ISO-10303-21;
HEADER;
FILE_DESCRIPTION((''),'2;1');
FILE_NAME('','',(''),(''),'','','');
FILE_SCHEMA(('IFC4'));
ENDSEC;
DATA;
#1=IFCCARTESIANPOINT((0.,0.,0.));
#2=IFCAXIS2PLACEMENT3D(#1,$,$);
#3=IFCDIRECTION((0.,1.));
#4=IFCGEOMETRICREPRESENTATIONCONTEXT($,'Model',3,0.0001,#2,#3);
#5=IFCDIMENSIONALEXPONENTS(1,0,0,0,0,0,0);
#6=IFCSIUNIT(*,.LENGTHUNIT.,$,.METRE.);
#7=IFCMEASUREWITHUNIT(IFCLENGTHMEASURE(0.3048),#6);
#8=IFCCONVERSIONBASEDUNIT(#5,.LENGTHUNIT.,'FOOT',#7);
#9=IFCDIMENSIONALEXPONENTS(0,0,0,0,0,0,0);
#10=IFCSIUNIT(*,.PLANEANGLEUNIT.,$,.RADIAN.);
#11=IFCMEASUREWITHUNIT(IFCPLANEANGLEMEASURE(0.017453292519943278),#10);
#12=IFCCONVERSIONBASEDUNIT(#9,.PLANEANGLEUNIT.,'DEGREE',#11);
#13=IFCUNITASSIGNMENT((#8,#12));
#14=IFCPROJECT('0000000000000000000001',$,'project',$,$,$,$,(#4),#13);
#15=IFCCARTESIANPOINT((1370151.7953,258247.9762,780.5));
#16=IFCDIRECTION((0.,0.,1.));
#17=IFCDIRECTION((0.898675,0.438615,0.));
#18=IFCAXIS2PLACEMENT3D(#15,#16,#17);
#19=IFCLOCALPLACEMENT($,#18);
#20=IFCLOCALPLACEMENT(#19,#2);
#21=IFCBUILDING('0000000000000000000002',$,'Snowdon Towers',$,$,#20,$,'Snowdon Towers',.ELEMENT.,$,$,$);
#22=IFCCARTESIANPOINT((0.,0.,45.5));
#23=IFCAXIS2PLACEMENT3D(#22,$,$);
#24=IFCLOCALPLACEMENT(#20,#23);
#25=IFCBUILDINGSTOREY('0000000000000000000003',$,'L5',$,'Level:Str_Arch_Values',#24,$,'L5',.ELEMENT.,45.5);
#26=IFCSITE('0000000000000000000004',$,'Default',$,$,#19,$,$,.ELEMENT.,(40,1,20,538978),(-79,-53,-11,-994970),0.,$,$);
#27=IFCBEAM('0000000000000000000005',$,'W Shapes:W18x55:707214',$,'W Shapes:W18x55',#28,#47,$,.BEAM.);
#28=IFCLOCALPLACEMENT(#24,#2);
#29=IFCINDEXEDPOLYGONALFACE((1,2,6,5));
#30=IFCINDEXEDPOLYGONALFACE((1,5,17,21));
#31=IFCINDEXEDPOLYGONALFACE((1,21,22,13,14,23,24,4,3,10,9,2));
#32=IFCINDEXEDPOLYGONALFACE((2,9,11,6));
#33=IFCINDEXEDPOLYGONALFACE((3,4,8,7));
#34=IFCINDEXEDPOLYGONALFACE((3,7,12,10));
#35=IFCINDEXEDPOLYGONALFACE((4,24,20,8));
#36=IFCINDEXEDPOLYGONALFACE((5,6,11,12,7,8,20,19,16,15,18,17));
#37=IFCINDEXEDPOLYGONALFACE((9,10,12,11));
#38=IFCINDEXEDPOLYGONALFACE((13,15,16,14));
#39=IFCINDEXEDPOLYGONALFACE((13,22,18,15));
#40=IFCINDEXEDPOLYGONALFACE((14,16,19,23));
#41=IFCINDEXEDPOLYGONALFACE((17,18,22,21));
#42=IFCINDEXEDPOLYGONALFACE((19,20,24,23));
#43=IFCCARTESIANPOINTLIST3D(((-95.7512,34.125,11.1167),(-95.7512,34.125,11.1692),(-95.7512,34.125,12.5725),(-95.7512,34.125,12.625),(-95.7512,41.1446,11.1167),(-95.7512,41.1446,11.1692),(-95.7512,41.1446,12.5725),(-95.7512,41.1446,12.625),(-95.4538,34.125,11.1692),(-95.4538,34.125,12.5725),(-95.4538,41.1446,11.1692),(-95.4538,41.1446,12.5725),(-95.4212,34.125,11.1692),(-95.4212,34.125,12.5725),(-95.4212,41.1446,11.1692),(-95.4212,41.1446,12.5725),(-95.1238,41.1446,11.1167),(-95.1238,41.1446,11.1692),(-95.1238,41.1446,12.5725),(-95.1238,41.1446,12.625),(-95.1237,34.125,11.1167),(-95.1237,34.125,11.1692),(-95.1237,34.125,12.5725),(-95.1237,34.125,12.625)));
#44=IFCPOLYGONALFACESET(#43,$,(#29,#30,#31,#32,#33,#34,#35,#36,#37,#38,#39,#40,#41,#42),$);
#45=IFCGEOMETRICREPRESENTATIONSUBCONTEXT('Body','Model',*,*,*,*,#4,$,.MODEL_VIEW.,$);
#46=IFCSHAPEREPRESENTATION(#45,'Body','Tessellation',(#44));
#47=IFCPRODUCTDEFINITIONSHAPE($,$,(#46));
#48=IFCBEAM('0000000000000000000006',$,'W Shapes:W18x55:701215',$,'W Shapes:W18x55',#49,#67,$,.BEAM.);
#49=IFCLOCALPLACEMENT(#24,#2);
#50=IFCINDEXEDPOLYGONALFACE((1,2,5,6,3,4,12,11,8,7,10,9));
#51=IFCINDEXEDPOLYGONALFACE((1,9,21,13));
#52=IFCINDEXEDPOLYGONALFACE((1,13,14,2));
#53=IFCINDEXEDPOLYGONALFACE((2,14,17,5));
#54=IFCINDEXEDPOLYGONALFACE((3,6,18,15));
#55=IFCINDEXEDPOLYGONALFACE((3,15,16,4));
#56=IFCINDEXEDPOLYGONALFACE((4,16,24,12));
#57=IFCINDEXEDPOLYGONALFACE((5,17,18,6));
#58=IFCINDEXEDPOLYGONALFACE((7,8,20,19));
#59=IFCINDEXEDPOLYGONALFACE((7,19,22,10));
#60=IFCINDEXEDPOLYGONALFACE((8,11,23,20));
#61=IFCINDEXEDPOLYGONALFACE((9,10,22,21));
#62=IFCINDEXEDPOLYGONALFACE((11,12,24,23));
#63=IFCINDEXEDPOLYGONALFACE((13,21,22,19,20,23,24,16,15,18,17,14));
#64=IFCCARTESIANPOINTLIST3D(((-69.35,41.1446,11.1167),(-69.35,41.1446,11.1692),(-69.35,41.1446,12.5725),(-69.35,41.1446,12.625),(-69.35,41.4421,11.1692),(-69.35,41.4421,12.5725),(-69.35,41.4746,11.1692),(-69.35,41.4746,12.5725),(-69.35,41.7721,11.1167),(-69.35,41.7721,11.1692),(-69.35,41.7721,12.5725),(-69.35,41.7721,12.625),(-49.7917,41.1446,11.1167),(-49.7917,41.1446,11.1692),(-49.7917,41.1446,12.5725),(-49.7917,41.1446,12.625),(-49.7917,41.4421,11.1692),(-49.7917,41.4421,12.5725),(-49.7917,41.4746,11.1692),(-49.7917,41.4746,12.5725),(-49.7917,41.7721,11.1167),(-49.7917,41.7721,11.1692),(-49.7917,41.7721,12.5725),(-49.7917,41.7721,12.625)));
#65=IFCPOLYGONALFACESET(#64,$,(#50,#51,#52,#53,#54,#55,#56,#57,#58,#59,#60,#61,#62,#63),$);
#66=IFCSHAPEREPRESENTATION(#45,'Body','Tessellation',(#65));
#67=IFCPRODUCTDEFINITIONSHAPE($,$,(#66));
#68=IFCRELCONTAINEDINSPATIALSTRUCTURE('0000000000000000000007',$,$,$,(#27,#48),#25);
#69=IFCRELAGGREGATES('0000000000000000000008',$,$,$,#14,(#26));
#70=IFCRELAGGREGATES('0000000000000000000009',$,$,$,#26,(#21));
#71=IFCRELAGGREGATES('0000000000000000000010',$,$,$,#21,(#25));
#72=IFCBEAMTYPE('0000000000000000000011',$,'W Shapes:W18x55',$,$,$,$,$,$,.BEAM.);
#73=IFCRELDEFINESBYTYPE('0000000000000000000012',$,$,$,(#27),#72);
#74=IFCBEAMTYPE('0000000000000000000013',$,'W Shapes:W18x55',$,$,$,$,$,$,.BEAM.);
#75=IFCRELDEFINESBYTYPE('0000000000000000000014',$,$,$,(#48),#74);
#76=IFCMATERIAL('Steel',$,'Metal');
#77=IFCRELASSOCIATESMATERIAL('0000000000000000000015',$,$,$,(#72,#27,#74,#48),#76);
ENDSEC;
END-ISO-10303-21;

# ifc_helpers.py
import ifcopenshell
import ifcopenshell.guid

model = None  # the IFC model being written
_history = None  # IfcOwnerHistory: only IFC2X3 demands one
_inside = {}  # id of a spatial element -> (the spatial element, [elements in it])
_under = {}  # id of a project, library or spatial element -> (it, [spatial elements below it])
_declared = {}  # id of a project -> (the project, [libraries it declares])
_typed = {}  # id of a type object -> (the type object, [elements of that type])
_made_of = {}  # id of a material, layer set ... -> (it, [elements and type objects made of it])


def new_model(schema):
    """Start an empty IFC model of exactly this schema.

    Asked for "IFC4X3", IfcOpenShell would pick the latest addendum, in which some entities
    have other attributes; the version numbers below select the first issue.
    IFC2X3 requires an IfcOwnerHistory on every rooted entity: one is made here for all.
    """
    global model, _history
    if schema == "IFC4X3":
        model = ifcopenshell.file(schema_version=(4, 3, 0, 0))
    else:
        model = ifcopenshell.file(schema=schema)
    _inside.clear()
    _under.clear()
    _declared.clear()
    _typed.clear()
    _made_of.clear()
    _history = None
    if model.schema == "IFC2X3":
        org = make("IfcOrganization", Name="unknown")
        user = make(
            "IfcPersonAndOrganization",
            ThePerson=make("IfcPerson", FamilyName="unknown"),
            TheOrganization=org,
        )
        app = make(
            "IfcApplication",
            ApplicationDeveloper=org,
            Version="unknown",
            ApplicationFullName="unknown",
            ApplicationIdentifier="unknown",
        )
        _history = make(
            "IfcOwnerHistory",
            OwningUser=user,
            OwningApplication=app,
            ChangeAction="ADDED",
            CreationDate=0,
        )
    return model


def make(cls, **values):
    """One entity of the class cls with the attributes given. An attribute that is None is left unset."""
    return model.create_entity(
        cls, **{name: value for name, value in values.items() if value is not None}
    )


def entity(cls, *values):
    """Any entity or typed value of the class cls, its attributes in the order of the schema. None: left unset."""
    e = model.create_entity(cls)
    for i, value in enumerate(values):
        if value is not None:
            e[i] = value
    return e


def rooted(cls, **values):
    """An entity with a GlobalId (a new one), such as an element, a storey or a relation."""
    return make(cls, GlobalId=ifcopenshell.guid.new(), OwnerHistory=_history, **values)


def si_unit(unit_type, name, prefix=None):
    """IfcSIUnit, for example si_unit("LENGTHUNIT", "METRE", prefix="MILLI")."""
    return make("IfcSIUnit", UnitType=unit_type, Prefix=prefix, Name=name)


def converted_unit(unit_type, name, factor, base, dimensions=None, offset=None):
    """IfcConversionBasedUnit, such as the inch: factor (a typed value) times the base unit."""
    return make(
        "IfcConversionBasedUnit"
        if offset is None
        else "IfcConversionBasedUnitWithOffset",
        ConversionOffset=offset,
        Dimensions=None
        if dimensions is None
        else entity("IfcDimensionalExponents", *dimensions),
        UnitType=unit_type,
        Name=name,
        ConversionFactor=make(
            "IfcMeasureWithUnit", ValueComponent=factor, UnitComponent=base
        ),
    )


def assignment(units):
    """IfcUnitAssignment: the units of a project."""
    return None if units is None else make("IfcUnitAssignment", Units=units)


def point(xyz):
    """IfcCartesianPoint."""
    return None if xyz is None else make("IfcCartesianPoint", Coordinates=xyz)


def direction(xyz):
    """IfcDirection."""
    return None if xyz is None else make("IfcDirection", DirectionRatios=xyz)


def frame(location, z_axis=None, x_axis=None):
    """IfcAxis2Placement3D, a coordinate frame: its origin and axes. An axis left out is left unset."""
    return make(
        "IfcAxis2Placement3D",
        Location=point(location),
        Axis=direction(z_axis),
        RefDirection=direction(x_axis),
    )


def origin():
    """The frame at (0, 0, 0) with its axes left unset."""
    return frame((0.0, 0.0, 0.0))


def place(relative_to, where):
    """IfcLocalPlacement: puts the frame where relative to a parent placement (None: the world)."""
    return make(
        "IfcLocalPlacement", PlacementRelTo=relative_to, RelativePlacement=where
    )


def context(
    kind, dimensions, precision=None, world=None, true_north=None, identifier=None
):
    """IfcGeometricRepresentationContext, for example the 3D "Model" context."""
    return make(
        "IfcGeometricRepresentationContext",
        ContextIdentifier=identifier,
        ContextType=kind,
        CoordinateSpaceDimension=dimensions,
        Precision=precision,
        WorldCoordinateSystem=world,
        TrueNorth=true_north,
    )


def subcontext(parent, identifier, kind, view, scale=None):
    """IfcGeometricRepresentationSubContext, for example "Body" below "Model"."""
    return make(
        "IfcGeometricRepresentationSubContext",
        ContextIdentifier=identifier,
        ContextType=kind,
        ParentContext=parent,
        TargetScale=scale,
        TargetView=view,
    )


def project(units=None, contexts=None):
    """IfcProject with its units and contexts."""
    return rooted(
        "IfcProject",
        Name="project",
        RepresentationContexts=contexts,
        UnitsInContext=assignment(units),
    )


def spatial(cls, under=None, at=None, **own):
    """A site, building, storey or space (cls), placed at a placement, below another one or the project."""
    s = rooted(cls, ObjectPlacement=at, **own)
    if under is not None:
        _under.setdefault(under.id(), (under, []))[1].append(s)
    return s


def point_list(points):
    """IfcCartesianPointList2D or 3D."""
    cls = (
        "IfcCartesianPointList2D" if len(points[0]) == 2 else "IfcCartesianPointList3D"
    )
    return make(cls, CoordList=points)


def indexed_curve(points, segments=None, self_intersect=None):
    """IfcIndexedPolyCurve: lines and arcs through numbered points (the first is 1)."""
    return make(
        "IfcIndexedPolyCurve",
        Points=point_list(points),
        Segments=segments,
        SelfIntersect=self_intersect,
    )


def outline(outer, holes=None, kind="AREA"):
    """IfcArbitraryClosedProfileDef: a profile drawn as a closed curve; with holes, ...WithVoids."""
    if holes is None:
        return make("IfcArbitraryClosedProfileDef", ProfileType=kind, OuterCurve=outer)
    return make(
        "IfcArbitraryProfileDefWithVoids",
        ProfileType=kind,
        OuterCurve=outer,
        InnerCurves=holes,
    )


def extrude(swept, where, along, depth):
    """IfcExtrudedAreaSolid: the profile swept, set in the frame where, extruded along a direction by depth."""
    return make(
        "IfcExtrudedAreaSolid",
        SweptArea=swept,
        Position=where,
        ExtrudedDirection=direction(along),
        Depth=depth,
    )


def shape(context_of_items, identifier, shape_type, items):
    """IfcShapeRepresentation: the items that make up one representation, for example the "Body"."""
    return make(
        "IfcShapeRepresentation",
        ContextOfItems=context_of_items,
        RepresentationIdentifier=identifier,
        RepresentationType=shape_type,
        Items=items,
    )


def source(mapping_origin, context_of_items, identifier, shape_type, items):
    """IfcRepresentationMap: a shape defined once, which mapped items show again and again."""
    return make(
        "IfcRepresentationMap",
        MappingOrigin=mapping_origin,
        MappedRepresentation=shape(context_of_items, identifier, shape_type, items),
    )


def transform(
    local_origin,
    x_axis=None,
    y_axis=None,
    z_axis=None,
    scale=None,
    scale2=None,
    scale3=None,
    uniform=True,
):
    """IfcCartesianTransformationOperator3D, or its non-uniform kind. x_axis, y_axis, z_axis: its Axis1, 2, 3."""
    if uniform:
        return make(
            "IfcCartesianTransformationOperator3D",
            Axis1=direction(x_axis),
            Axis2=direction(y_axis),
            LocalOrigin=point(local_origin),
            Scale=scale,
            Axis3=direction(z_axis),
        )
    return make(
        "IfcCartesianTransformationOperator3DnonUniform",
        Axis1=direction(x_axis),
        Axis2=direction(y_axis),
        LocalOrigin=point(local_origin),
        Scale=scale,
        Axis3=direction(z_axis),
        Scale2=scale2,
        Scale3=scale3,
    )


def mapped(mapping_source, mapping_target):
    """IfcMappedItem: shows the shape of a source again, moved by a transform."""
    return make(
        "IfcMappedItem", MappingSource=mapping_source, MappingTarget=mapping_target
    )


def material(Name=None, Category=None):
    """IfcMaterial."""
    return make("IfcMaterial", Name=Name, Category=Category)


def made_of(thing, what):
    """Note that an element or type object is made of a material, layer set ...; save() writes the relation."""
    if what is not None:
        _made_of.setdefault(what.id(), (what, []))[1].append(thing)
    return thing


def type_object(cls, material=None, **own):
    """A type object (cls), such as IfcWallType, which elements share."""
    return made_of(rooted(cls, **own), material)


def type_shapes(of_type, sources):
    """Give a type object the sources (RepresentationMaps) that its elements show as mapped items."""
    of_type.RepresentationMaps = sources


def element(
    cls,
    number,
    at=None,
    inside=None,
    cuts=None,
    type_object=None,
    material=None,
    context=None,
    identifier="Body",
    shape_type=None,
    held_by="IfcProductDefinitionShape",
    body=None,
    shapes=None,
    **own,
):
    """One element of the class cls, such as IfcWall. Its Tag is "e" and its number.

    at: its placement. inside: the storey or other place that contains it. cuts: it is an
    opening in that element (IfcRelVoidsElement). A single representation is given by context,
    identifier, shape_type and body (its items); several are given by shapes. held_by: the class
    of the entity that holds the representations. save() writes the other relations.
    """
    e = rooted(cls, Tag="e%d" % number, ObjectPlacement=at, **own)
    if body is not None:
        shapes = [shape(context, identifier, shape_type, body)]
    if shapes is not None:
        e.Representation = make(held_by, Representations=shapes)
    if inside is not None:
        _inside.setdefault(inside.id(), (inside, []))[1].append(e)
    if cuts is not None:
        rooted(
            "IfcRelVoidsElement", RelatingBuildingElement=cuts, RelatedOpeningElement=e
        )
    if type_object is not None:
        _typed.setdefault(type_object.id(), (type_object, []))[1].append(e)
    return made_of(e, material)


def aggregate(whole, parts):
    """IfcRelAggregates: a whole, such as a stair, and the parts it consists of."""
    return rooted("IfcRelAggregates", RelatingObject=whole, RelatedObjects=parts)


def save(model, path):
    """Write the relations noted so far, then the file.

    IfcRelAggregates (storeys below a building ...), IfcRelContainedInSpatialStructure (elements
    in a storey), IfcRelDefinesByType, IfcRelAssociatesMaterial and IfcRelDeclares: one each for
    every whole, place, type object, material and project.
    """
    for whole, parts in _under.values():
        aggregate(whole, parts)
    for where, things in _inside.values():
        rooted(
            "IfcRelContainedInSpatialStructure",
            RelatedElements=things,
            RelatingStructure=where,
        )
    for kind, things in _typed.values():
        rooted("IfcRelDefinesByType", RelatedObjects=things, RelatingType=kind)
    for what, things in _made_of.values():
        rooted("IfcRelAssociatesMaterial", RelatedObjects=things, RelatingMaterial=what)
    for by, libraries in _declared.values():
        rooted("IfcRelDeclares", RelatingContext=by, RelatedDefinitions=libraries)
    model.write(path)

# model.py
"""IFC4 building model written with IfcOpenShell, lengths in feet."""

from ifc_helpers import new_model, entity, si_unit, converted_unit, direction, frame, origin, place, context, subcontext, project, spatial, indexed_curve, outline, extrude, source, transform, mapped, material, type_object, type_shapes, element, save


model = new_model("IFC4")

# Units and contexts
model_context = context("Model", 3, precision=0.0001, world=origin(), true_north=direction((0.0, 1.0)))
body_context = subcontext(model_context, "Body", "Model", "MODEL_VIEW")
ifc_project = project(units=[converted_unit("LENGTHUNIT", "FOOT", entity("IfcLengthMeasure", 0.3048), si_unit("LENGTHUNIT", "METRE"), dimensions=[1, 0, 0, 0, 0, 0, 0]), converted_unit("PLANEANGLEUNIT", "DEGREE", entity("IfcPlaneAngleMeasure", 0.017453292519943278), si_unit("PLANEANGLEUNIT", "RADIAN"), dimensions=[0, 0, 0, 0, 0, 0, 0])], contexts=[model_context])

# Site, building, storey
site_placement = place(None, frame((1370151.7953, 258247.9762, 780.5), z_axis=(0.0, 0.0, 1.0), x_axis=(0.898675, 0.438615, 0.0)))
site = spatial("IfcSite", under=ifc_project, at=site_placement, Name="Default", CompositionType="ELEMENT", RefLatitude=(40, 1, 20, 538978), RefLongitude=(-79, -53, -11, -994970), RefElevation=0.0)
building_placement = place(site_placement, origin())
building = spatial("IfcBuilding", under=site, at=building_placement, Name="Snowdon Towers", LongName="Snowdon Towers", CompositionType="ELEMENT")
storey_placement = place(building_placement, frame((0.0, 0.0, 45.5)))
storey = spatial("IfcBuildingStorey", under=building, at=storey_placement, Name="L5", ObjectType="Level:Str_Arch_Values", LongName="L5", CompositionType="ELEMENT", Elevation=45.5)

# Beams
ifc_material = material(Name="Steel", Category="Metal")
beam_type_1 = type_object("IfcBeamType", Name="W Shapes:W18x55", PredefinedType="BEAM", material=ifc_material)
shared_shape_1 = source(origin(), body_context, "Body", "SweptSolid", [
    extrude(outline(indexed_curve([(-0.3138, -0.7017), (-0.3138, -0.7542), (0.3138, -0.7542), (0.3138, -0.7017), (0.0162, -0.7017), (0.0162, 0.7017), (0.3138, 0.7017), (0.3138, 0.7542), (-0.3137, 0.7542), (-0.3137, 0.7017), (-0.0163, 0.7017), (-0.0163, -0.7017), (-0.3138, -0.7017)], self_intersect=False)), frame((-3.3529, 0.0, 0.0), z_axis=(-1.0, 0.0, 0.0), x_axis=(0.0, -1.0, 0.0)), (0.0, 0.0, -1.0), 7.0196),
])
type_shapes(beam_type_1, [shared_shape_1])
beam_1_placement = place(storey_placement, frame((-95.4375, 37.7917, 11.8708), z_axis=(0.0, 0.0, 1.0), x_axis=(0.0, -1.0, 0.0)))
element("IfcBeam", 1, at=beam_1_placement, inside=storey, type_object=beam_type_1, material=ifc_material, Name="W Shapes:W18x55:707214", ObjectType="W Shapes:W18x55", PredefinedType="BEAM", context=body_context, shape_type="MappedRepresentation", body=[
    mapped(shared_shape_1, transform((0.0, 0.0, 0.0), scale=1.0)),
])
beam_type_2 = type_object("IfcBeamType", Name="W Shapes:W18x55", PredefinedType="BEAM", material=ifc_material)
shared_shape_2 = source(origin(), body_context, "Body", "SweptSolid", [
    extrude(outline(indexed_curve([(-0.3138, -0.7017), (-0.3138, -0.7542), (0.3138, -0.7542), (0.3138, -0.7017), (0.0162, -0.7017), (0.0162, 0.7017), (0.3138, 0.7017), (0.3138, 0.7542), (-0.3137, 0.7542), (-0.3137, 0.7017), (-0.0163, 0.7017), (-0.0163, -0.7017), (-0.3138, -0.7017)], self_intersect=False)), frame((-9.725, 0.0, 0.0), z_axis=(-1.0, 0.0, 0.0), x_axis=(0.0, -1.0, 0.0)), (0.0, 0.0, -1.0), 19.5583),
])
type_shapes(beam_type_2, [shared_shape_2])
beam_2_placement = place(storey_placement, frame((-59.625, 41.4583, 11.8708)))
element("IfcBeam", 2, at=beam_2_placement, inside=storey, type_object=beam_type_2, material=ifc_material, Name="W Shapes:W18x55:701215", ObjectType="W Shapes:W18x55", PredefinedType="BEAM", context=body_context, shape_type="MappedRepresentation", body=[
    mapped(shared_shape_2, transform((0.0, 0.0, 0.0), scale=1.0)),
])

save(model, "model.ifc")
